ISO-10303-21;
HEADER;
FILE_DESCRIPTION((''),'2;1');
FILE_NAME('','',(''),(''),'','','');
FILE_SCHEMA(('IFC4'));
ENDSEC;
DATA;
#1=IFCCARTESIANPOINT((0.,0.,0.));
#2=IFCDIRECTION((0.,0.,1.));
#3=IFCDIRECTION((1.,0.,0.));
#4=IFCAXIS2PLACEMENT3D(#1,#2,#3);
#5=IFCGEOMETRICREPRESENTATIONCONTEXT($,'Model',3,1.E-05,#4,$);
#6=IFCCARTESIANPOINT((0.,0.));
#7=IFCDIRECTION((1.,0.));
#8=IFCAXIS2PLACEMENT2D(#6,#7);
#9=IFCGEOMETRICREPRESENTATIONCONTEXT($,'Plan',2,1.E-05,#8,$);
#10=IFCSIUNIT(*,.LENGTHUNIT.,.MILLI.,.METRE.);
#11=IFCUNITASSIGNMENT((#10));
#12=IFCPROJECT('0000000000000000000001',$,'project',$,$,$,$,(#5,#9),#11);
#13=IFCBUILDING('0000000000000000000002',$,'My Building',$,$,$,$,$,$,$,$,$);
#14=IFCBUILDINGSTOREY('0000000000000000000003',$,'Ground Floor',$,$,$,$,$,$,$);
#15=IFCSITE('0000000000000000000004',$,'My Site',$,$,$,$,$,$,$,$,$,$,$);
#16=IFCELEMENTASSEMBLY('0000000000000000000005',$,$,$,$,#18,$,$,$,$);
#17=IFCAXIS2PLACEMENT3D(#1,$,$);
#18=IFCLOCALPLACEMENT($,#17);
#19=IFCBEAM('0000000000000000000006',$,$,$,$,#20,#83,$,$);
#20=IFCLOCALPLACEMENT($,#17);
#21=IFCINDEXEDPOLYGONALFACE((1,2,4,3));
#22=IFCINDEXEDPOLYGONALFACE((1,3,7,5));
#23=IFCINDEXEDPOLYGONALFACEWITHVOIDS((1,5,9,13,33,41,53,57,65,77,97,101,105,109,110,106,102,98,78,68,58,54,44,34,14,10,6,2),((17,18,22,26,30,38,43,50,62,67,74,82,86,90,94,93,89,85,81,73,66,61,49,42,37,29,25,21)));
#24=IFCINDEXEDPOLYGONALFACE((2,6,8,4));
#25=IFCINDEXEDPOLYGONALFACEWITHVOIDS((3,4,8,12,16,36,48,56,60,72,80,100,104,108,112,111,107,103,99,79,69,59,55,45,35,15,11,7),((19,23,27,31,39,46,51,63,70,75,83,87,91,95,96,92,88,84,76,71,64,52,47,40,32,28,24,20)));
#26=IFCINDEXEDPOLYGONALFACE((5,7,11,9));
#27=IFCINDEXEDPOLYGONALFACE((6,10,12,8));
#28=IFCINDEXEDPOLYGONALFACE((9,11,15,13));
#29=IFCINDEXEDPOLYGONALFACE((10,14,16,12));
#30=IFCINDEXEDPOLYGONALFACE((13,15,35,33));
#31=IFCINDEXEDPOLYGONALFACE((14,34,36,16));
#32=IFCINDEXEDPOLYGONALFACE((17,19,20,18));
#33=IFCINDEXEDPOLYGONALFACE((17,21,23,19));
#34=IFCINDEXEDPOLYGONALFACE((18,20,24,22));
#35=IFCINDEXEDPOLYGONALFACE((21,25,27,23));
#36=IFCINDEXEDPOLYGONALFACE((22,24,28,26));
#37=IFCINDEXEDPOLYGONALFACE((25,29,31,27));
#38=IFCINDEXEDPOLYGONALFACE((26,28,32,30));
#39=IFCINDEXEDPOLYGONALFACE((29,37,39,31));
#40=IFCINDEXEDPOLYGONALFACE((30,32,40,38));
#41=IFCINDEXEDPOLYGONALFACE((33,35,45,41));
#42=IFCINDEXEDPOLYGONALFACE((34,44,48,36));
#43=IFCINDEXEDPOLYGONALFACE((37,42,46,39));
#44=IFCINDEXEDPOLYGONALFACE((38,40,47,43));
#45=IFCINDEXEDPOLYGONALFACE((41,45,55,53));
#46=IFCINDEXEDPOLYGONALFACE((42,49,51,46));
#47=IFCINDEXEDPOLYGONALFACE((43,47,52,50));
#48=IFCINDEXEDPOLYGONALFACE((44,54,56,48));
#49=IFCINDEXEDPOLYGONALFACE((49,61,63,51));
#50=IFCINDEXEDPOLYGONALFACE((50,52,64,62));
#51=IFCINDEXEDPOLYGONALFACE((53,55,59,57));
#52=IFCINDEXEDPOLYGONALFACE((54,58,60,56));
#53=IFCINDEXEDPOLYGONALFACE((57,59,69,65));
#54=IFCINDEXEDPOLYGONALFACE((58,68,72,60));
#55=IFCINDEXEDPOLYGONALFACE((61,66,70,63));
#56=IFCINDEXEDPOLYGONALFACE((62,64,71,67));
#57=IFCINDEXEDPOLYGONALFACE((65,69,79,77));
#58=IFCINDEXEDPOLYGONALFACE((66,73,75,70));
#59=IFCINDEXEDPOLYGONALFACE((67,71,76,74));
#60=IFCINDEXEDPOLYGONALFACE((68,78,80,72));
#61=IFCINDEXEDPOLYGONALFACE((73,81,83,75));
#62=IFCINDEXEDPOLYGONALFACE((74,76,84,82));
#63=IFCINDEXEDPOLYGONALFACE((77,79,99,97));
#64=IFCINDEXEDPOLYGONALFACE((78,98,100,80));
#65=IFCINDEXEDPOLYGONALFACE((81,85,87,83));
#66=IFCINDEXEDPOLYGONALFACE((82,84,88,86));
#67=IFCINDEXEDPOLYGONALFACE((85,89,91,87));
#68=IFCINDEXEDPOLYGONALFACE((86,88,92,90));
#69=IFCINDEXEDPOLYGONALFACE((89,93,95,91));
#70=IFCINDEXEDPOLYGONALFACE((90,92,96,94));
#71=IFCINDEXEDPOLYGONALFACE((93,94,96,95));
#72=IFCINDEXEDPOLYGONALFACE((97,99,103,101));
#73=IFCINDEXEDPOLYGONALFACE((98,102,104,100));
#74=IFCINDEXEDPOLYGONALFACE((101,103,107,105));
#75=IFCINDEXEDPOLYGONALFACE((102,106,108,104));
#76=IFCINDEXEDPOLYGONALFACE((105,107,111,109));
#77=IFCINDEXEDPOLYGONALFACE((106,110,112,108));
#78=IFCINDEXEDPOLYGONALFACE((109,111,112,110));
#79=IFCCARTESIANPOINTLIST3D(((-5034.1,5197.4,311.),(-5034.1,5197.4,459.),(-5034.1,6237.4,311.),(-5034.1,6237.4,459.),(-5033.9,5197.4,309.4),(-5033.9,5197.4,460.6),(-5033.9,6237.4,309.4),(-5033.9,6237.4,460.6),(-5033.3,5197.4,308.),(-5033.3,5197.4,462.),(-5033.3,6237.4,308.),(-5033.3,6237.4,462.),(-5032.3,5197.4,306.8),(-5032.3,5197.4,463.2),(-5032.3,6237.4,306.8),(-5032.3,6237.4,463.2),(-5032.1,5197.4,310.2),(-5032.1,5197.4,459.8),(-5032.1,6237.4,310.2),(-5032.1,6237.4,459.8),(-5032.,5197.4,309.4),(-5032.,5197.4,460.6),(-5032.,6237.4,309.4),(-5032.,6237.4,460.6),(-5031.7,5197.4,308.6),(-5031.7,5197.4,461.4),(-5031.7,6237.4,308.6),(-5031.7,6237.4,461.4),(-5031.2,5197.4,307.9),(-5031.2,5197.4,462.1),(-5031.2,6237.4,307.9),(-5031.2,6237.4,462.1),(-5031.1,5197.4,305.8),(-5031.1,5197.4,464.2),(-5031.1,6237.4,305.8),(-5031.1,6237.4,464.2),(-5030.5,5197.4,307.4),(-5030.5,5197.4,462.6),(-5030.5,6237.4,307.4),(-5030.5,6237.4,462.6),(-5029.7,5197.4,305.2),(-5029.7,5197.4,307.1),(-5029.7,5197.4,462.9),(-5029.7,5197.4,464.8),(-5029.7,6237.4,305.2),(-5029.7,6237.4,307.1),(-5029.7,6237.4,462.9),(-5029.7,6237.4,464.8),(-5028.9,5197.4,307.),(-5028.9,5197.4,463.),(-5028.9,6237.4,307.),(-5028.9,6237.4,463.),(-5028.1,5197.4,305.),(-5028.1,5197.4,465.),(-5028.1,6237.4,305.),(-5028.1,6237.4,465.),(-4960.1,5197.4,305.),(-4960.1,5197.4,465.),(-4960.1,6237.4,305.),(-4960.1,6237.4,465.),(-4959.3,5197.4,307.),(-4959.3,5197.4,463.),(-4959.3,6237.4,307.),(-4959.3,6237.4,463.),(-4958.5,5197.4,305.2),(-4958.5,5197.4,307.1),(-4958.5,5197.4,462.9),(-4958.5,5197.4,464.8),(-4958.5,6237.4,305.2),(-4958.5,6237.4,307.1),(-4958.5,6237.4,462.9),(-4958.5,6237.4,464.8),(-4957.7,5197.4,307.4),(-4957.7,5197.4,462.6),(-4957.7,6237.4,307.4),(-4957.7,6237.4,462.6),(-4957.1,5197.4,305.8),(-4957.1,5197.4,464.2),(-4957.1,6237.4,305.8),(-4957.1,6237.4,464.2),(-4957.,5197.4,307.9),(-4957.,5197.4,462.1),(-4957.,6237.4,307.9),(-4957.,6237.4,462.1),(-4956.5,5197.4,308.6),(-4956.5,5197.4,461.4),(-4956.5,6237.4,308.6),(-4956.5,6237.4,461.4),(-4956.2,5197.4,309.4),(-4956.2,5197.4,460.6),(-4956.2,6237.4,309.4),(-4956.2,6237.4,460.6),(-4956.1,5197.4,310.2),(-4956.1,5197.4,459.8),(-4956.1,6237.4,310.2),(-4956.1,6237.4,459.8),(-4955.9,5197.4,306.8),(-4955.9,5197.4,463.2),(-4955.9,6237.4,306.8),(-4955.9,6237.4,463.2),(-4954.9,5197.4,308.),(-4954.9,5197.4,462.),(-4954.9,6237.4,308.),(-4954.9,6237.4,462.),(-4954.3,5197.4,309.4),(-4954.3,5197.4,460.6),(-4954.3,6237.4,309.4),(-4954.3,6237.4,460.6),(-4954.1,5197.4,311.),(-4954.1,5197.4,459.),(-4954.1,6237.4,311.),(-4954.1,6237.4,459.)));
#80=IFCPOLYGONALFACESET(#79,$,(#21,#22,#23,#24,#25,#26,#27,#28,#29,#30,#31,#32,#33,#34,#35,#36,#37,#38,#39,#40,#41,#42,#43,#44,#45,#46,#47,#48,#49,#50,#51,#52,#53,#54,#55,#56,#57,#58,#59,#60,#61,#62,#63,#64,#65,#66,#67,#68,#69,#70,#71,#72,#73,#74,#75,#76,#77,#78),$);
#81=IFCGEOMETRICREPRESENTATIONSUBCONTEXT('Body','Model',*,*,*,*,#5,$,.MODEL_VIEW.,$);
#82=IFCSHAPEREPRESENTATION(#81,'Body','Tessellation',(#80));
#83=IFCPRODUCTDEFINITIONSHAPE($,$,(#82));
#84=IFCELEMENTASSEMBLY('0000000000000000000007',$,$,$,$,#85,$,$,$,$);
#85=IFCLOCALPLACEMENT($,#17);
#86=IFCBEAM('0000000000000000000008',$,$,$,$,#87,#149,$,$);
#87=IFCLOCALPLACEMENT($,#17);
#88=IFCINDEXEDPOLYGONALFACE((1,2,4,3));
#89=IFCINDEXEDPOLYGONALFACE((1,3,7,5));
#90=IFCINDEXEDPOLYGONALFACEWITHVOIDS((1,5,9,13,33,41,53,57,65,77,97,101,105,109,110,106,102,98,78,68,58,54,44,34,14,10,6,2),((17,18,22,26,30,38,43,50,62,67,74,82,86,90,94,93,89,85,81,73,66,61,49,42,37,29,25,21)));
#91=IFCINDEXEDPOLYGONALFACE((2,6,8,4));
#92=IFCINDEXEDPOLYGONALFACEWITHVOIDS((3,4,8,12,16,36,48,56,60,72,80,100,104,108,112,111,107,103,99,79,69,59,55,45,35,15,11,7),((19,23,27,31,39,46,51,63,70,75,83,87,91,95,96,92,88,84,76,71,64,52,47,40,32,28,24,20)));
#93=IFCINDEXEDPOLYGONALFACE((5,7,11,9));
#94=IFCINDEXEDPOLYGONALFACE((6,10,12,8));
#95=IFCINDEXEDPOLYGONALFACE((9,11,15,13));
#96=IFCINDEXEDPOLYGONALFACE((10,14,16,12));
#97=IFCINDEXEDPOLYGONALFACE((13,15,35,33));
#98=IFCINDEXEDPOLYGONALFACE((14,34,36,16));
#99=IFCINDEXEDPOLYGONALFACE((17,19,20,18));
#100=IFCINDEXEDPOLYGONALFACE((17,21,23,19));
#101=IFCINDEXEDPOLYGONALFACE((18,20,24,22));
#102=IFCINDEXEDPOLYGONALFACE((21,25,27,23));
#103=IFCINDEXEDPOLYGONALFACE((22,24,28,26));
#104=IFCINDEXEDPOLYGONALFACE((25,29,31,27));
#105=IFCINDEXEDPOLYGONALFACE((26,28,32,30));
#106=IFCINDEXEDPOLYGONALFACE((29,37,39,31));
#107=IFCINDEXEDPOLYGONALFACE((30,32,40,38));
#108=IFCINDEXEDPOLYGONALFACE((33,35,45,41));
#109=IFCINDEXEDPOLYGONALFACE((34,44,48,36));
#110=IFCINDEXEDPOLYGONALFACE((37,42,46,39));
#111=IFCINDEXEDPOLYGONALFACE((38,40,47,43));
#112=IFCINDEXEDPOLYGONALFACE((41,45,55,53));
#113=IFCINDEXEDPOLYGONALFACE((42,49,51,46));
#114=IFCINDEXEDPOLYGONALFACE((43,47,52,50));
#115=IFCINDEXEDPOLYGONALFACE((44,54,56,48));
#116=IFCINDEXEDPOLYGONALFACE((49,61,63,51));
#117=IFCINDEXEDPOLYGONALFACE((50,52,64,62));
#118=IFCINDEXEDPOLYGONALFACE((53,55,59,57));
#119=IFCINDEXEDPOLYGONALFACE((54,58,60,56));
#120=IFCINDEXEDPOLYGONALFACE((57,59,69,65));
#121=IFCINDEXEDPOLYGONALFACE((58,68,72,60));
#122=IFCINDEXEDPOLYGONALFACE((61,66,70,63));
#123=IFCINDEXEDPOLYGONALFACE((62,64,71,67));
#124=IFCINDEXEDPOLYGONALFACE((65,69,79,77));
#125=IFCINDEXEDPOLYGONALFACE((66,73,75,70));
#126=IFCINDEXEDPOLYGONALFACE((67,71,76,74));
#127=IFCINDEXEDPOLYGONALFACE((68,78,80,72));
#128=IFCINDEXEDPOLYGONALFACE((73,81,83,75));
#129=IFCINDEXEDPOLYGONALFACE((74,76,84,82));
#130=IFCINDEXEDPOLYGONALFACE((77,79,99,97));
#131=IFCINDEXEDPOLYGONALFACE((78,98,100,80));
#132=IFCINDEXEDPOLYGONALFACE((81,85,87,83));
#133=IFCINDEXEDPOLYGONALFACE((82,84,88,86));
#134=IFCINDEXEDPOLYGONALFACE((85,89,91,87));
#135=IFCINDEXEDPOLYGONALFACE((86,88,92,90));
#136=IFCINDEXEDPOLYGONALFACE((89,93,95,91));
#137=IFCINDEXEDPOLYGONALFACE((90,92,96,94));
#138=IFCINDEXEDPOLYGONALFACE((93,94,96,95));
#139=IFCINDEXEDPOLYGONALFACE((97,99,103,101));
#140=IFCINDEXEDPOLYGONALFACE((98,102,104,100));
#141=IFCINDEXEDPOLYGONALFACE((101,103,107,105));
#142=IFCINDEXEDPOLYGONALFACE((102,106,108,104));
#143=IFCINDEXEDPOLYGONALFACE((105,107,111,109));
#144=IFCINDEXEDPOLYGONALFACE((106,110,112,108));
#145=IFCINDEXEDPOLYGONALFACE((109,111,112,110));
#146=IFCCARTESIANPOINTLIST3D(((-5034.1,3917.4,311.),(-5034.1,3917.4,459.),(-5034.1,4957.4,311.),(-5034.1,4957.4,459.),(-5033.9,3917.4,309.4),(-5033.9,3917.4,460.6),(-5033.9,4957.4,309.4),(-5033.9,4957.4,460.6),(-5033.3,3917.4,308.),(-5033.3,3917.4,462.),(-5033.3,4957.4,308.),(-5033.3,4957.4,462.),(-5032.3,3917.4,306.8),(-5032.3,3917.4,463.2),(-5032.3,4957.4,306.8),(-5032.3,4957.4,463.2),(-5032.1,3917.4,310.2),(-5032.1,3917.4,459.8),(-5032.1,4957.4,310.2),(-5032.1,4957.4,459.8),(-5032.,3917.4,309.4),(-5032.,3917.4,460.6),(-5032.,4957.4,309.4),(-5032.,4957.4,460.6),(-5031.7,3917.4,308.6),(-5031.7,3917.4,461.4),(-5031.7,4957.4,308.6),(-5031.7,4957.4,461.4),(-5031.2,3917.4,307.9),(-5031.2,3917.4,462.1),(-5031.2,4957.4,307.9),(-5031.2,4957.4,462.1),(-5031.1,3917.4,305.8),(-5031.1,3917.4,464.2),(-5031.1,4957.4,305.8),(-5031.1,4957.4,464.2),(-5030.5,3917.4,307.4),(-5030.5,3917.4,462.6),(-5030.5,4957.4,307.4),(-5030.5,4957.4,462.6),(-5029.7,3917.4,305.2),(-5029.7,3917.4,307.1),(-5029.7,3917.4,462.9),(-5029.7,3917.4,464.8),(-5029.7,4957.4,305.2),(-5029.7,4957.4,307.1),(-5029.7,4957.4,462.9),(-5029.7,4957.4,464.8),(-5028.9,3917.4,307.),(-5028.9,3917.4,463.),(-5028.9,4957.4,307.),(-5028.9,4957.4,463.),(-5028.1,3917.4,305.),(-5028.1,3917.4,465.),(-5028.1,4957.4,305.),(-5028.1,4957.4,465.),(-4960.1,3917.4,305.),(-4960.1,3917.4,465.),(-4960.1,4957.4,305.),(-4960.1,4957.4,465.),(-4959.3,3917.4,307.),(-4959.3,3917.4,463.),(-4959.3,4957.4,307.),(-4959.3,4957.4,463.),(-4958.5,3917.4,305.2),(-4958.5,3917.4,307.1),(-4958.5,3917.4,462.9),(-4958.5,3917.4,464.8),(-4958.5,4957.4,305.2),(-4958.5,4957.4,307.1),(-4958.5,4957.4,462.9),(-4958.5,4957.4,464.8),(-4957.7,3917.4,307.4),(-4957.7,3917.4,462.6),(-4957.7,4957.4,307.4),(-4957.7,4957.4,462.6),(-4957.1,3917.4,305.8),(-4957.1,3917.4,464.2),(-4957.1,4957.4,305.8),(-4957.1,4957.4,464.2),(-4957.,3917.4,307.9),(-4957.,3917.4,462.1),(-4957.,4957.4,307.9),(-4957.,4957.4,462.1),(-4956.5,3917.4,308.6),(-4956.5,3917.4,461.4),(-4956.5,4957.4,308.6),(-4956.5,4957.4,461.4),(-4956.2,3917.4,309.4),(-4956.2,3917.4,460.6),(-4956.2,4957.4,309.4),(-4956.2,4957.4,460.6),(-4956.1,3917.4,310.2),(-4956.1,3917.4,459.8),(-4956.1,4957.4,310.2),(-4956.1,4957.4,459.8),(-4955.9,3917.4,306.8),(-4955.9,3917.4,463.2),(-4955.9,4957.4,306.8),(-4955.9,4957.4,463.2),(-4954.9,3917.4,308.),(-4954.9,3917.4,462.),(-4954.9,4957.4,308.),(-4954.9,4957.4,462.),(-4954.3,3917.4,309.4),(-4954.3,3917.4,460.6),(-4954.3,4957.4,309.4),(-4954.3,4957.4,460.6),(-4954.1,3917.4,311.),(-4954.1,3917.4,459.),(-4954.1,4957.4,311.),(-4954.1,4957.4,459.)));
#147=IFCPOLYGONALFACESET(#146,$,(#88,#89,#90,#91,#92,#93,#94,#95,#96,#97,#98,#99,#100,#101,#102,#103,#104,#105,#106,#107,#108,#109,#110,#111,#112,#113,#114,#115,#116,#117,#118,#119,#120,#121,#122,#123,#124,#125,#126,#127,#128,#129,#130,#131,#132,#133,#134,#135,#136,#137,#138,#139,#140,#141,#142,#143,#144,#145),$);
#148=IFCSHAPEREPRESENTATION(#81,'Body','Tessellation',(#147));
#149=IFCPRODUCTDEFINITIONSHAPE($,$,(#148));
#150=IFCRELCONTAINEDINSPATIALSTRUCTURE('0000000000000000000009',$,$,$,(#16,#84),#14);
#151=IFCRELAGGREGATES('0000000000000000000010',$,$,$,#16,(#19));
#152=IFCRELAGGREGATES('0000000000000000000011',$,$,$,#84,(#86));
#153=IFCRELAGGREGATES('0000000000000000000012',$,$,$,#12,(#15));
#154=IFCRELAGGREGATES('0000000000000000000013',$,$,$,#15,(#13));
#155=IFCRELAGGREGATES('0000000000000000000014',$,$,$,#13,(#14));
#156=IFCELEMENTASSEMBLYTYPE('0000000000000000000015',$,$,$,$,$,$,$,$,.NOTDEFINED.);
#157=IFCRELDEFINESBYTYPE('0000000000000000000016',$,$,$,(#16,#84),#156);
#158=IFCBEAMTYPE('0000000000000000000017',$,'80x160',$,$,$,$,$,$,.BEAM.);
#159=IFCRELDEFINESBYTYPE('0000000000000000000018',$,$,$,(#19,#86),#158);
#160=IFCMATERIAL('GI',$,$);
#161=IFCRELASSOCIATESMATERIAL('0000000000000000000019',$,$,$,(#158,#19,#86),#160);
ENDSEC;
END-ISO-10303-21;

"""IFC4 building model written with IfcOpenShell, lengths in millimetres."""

from ifc_helpers import new_model, si_unit, frame, origin_with_axes, origin_2d_with_axis, place, context, subcontext, project, spatial, hollow_rectangle, extrude, material, material_profile, profile_set, profile_usage, type_object, element, aggregate, save


model = new_model("IFC4")

# Units and contexts
model_context = context("Model", 3, precision=1e-05, world=origin_with_axes())
plan_context = context("Plan", 2, precision=1e-05, world=origin_2d_with_axis())
body_context = subcontext(model_context, "Body", "Model", "MODEL_VIEW")
ifc_project = project(units=[si_unit("LENGTHUNIT", "METRE", prefix="MILLI")], contexts=[model_context, plan_context])

# Site, building, storey
site = spatial("IfcSite", under=ifc_project, Name="My Site")
building = spatial("IfcBuilding", under=site, Name="My Building")
storey = spatial("IfcBuildingStorey", under=building, Name="Ground Floor")

# Shared definitions
ifc_material = material(Name="GI")

# Element assemblies, beams
element_assembly_type_1 = type_object("IfcElementAssemblyType", PredefinedType="NOTDEFINED")
assembly_1_placement = place(None, frame((-4994.1, 5117.4, 385.0), z_axis=(0.0, 1.0, 0.0), x_axis=(1.0, 0.0, 0.0)))
assembly_1 = element("IfcElementAssembly", 1, at=assembly_1_placement, inside=storey, type_object=element_assembly_type_1)
ifc_material_profile_1 = material_profile(ifc_material, hollow_rectangle(XDim=80.0, YDim=160.0, WallThickness=2.0, InnerFilletRadius=3.2, OuterFilletRadius=6.0))
ifc_profile_set_1 = profile_set([ifc_material_profile_1], Name="80x160 GI Rectangular Hollow")
ifc_profile_usage_1 = profile_usage(ifc_profile_set_1)
beam_type = type_object("IfcBeamType", Name="80x160", PredefinedType="BEAM", material=ifc_profile_set_1)
beam_1_placement = place(assembly_1_placement, frame((0.0, 0.0, 80.0), z_axis=(0.0, 0.0, 1.0), x_axis=(1.0, 0.0, 0.0)))
beam_1 = element("IfcBeam", 2, at=beam_1_placement, type_object=beam_type, material=ifc_profile_usage_1, context=body_context, shape_type="SweptSolid", body=[
    extrude(hollow_rectangle(XDim=80.0, YDim=160.0, WallThickness=2.0, InnerFilletRadius=3.2, OuterFilletRadius=6.0), origin_with_axes(), (0.0, 0.0, 1.0), 1040.0),
])
aggregate(assembly_1, [beam_1])
assembly_2_placement = place(None, frame((-4994.1, 3837.4, 385.0), z_axis=(0.0, 1.0, 0.0), x_axis=(1.0, 0.0, 0.0)))
assembly_2 = element("IfcElementAssembly", 3, at=assembly_2_placement, inside=storey, type_object=element_assembly_type_1)
ifc_profile_usage_2 = profile_usage(ifc_profile_set_1)
beam_2_placement = place(assembly_2_placement, frame((0.0, 0.0, 80.0), z_axis=(0.0, 0.0, 1.0), x_axis=(1.0, 0.0, 0.0)))
beam_2 = element("IfcBeam", 4, at=beam_2_placement, type_object=beam_type, material=ifc_profile_usage_2, context=body_context, shape_type="SweptSolid", body=[
    extrude(hollow_rectangle(XDim=80.0, YDim=160.0, WallThickness=2.0, InnerFilletRadius=3.2, OuterFilletRadius=6.0), origin_with_axes(), (0.0, 0.0, 1.0), 1040.0),
])
aggregate(assembly_2, [beam_2])

save(model, "model.ifc")
